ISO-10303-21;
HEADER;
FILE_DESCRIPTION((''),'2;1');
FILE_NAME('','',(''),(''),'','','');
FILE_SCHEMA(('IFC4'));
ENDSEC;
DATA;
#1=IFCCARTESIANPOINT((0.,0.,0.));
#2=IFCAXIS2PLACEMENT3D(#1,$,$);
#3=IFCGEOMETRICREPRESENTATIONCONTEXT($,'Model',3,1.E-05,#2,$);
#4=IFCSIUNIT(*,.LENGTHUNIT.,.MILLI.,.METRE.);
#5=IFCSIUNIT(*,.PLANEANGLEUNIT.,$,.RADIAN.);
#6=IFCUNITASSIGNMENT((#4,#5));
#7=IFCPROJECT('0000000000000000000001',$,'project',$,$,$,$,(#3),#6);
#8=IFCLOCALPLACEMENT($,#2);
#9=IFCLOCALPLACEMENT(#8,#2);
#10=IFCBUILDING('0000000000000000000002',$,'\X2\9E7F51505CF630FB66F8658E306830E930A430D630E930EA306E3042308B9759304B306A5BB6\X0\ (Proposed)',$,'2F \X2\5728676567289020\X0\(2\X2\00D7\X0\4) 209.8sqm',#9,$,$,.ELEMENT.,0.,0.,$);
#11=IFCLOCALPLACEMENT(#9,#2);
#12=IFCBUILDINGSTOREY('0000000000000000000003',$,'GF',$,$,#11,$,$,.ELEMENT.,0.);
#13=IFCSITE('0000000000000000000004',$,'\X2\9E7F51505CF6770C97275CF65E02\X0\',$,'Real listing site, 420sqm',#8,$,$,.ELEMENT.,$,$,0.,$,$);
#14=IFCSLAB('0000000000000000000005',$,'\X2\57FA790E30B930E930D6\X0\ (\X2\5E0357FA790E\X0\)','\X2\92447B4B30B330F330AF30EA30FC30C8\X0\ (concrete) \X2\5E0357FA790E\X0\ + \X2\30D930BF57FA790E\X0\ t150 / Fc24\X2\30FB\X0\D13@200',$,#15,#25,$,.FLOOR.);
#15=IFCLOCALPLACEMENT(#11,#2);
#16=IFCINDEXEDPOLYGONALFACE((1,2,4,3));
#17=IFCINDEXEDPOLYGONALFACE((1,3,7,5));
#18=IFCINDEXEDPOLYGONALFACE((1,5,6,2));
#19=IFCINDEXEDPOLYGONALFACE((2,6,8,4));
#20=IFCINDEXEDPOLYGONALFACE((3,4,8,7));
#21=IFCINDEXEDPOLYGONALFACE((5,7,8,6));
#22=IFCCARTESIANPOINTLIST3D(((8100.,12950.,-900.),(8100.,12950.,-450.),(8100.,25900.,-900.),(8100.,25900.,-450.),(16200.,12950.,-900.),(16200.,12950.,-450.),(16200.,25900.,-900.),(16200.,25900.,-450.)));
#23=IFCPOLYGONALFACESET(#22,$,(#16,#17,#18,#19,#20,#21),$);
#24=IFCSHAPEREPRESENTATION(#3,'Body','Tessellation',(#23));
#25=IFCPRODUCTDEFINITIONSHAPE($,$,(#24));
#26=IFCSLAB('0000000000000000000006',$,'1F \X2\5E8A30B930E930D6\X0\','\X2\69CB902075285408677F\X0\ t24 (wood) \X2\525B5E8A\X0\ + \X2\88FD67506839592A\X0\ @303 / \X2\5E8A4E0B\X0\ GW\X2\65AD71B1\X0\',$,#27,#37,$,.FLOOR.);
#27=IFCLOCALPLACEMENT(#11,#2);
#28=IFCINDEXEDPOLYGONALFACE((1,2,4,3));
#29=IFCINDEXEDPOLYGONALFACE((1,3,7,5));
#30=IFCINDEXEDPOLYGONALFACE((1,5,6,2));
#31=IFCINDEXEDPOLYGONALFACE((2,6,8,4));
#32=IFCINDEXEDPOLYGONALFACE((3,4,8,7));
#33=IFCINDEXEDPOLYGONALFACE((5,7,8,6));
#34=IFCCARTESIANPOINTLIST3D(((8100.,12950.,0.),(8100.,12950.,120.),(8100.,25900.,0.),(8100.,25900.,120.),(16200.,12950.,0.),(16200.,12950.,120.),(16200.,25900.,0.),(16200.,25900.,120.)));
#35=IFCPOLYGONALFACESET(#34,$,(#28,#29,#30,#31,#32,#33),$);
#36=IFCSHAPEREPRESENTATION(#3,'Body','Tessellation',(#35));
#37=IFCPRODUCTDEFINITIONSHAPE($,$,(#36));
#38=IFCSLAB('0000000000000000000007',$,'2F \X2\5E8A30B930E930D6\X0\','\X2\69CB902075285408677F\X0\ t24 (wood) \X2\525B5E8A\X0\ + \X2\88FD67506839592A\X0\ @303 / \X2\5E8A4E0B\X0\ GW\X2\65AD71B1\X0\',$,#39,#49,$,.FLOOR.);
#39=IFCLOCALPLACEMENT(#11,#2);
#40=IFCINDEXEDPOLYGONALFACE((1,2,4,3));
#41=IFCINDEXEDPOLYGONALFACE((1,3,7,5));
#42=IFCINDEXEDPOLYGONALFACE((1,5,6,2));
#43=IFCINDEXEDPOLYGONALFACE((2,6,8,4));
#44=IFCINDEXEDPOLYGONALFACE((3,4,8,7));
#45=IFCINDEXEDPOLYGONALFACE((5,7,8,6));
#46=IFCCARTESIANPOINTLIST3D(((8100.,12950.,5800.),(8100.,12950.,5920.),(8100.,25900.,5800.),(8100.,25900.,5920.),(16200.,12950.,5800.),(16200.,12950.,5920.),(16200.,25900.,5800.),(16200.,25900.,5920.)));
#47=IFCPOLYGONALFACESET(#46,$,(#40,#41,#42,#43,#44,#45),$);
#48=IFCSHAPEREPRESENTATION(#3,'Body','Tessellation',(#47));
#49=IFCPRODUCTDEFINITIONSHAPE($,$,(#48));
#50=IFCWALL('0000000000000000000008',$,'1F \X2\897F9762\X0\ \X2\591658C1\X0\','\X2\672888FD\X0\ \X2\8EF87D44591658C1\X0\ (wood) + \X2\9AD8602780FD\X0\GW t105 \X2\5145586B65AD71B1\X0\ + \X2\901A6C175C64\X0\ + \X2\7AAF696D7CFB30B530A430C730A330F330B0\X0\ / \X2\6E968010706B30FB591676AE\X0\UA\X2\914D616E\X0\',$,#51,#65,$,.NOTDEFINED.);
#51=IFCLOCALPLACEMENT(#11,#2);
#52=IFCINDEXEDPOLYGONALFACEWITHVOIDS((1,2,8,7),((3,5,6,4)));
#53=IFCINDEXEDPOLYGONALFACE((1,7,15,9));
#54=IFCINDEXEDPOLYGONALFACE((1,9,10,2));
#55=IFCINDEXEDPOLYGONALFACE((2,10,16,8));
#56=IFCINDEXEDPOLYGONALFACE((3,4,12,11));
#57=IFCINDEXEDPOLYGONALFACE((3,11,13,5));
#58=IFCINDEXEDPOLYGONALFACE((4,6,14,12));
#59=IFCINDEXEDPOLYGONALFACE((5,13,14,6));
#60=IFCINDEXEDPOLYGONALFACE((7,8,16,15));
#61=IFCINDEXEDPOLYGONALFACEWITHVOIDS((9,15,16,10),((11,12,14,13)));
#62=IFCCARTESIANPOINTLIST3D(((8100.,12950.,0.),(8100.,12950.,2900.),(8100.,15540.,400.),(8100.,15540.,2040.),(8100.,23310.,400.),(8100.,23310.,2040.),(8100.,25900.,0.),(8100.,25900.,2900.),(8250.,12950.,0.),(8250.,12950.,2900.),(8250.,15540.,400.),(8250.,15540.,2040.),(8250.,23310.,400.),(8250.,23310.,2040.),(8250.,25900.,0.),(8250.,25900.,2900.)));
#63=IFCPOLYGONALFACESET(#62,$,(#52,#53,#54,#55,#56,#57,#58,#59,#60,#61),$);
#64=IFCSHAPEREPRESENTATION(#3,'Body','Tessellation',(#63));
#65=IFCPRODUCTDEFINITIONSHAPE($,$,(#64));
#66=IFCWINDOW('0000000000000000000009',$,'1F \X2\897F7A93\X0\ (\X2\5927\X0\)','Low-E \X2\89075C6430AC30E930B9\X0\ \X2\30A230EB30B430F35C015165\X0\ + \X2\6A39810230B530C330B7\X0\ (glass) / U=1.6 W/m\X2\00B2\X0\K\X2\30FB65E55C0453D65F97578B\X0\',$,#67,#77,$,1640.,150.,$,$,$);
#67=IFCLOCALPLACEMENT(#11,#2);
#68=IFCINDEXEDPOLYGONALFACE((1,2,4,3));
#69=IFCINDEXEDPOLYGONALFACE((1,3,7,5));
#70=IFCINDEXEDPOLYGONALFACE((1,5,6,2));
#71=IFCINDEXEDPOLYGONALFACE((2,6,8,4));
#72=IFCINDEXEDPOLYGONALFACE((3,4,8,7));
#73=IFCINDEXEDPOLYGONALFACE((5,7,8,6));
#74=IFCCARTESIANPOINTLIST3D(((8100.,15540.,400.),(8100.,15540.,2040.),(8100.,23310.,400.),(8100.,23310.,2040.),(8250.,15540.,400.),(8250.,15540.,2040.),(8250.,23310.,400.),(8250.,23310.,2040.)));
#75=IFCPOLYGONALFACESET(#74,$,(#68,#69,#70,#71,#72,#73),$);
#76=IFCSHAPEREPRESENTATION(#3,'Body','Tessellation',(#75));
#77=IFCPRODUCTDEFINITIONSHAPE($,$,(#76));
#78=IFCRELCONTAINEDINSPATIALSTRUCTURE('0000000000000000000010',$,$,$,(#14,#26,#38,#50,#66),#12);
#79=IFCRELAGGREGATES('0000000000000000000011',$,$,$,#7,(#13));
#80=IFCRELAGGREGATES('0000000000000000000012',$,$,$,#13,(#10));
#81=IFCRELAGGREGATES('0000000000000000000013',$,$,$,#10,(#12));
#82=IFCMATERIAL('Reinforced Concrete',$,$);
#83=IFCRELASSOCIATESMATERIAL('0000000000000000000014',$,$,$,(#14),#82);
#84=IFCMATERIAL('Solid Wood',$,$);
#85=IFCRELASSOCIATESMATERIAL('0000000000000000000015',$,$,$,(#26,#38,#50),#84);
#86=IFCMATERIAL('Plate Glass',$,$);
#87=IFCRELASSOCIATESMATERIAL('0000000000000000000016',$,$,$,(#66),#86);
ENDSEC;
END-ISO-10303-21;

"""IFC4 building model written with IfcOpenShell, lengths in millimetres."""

from ifc_helpers import new_model, si_unit, frame, frame_2d, origin, place, context, project, spatial, rectangle, extrude, material, element, fill, save


model = new_model("IFC4")

# Units and contexts
model_context = context("Model", 3, precision=1e-05, world=origin())
ifc_project = project(units=[si_unit("LENGTHUNIT", "METRE", prefix="MILLI"), si_unit("PLANEANGLEUNIT", "RADIAN")], contexts=[model_context])

# Site, building, storey
site_placement = place(None, origin())
site = spatial("IfcSite", under=ifc_project, at=site_placement, Name="鹿児島県霧島市", ObjectType="Real listing site, 420sqm", CompositionType="ELEMENT", RefElevation=0.0)
building_placement = place(site_placement, origin())
building = spatial("IfcBuilding", under=site, at=building_placement, Name="鹿児島・書斎とライブラリのある静かな家 (Proposed)", ObjectType="2F 在来木造(2×4) 209.8sqm", CompositionType="ELEMENT", ElevationOfRefHeight=0.0, ElevationOfTerrain=0.0)
storey_placement = place(building_placement, origin())
storey = spatial("IfcBuildingStorey", under=building, at=storey_placement, Name="GF", CompositionType="ELEMENT", Elevation=0.0)

# Shared definitions
ifc_material_1 = material(Name="Solid Wood")

# Slabs
ifc_material_2 = material(Name="Reinforced Concrete")
slab_1_placement = place(storey_placement, frame((4050.0, 6475.0, -450.0)))
element("IfcSlab", 1, at=slab_1_placement, inside=storey, material=ifc_material_2, Name="基礎スラブ (布基礎)", Description="鉄筋コンクリート (concrete) 布基礎 + ベタ基礎 t150 / Fc24・D13@200", PredefinedType="FLOOR", context=model_context, shape_type="SweptSolid", body=[
    extrude(rectangle(XDim=8100.0, YDim=12950.0, at=frame_2d((4050.0, 6475.0))), frame((4050.0, 6475.0, -450.0)), (0.0, 0.0, 1.0), 450.0),
])
slab_2_placement = place(storey_placement, frame((4050.0, 6475.0, 0.0)))
element("IfcSlab", 2, at=slab_2_placement, inside=storey, material=ifc_material_1, Name="1F 床スラブ", Description="構造用合板 t24 (wood) 剛床 + 製材根太 @303 / 床下 GW断熱", PredefinedType="FLOOR", context=model_context, shape_type="SweptSolid", body=[
    extrude(rectangle(XDim=8100.0, YDim=12950.0, at=frame_2d((4050.0, 6475.0))), frame((4050.0, 6475.0, 0.0)), (0.0, 0.0, 1.0), 120.0),
])
slab_3_placement = place(storey_placement, frame((4050.0, 6475.0, 2900.0)))
element("IfcSlab", 3, at=slab_3_placement, inside=storey, material=ifc_material_1, Name="2F 床スラブ", Description="構造用合板 t24 (wood) 剛床 + 製材根太 @303 / 床下 GW断熱", PredefinedType="FLOOR", context=model_context, shape_type="SweptSolid", body=[
    extrude(rectangle(XDim=8100.0, YDim=12950.0, at=frame_2d((4050.0, 6475.0))), frame((4050.0, 6475.0, 2900.0)), (0.0, 0.0, 1.0), 120.0),
])

# Shared definitions
ifc_material_3 = material(Name="Plate Glass")

# Wall, opening, window
wall_1_placement = place(storey_placement, frame((4050.0, 6475.0, 0.0)))
wall_1 = element("IfcWall", 4, at=wall_1_placement, inside=storey, material=ifc_material_1, Name="1F 西面 外壁", Description="木製 軸組外壁 (wood) + 高性能GW t105 充填断熱 + 通気層 + 窯業系サイディング / 準耐火・外皮UA配慮", PredefinedType="NOTDEFINED", context=model_context, shape_type="SweptSolid", body=[
    extrude(rectangle(XDim=150.0, YDim=12950.0, at=frame_2d((75.0, 6475.0))), frame((4050.0, 6475.0, 0.0)), (0.0, 0.0, 1.0), 2900.0),
])
opening_1_placement = place(storey_placement, frame((4050.0, 7770.0, 200.0)))
opening_1 = element("IfcOpeningElement", 5, at=opening_1_placement, cuts=wall_1, PredefinedType="NOTDEFINED", context=model_context, shape_type="SweptSolid", body=[
    extrude(rectangle(XDim=150.0, YDim=7770.0, at=frame_2d((75.0, 3885.0))), frame((4050.0, 7770.0, 200.0)), (0.0, 0.0, 1.0), 1640.0),
])
window_1_placement = place(storey_placement, frame((4050.0, 7770.0, 200.0)))
window_1 = element("IfcWindow", 6, at=window_1_placement, inside=storey, material=ifc_material_3, Name="1F 西窓 (大)", Description="Low-E 複層ガラス アルゴン封入 + 樹脂サッシ (glass) / U=1.6 W/m²K・日射取得型", OverallHeight=1640.0, OverallWidth=150.0, context=model_context, shape_type="SweptSolid", body=[
    extrude(rectangle(XDim=150.0, YDim=7770.0, at=frame_2d((75.0, 3885.0))), frame((4050.0, 7770.0, 200.0)), (0.0, 0.0, 1.0), 1640.0),
])
fill(opening_1, window_1)

save(model, "model.ifc")
